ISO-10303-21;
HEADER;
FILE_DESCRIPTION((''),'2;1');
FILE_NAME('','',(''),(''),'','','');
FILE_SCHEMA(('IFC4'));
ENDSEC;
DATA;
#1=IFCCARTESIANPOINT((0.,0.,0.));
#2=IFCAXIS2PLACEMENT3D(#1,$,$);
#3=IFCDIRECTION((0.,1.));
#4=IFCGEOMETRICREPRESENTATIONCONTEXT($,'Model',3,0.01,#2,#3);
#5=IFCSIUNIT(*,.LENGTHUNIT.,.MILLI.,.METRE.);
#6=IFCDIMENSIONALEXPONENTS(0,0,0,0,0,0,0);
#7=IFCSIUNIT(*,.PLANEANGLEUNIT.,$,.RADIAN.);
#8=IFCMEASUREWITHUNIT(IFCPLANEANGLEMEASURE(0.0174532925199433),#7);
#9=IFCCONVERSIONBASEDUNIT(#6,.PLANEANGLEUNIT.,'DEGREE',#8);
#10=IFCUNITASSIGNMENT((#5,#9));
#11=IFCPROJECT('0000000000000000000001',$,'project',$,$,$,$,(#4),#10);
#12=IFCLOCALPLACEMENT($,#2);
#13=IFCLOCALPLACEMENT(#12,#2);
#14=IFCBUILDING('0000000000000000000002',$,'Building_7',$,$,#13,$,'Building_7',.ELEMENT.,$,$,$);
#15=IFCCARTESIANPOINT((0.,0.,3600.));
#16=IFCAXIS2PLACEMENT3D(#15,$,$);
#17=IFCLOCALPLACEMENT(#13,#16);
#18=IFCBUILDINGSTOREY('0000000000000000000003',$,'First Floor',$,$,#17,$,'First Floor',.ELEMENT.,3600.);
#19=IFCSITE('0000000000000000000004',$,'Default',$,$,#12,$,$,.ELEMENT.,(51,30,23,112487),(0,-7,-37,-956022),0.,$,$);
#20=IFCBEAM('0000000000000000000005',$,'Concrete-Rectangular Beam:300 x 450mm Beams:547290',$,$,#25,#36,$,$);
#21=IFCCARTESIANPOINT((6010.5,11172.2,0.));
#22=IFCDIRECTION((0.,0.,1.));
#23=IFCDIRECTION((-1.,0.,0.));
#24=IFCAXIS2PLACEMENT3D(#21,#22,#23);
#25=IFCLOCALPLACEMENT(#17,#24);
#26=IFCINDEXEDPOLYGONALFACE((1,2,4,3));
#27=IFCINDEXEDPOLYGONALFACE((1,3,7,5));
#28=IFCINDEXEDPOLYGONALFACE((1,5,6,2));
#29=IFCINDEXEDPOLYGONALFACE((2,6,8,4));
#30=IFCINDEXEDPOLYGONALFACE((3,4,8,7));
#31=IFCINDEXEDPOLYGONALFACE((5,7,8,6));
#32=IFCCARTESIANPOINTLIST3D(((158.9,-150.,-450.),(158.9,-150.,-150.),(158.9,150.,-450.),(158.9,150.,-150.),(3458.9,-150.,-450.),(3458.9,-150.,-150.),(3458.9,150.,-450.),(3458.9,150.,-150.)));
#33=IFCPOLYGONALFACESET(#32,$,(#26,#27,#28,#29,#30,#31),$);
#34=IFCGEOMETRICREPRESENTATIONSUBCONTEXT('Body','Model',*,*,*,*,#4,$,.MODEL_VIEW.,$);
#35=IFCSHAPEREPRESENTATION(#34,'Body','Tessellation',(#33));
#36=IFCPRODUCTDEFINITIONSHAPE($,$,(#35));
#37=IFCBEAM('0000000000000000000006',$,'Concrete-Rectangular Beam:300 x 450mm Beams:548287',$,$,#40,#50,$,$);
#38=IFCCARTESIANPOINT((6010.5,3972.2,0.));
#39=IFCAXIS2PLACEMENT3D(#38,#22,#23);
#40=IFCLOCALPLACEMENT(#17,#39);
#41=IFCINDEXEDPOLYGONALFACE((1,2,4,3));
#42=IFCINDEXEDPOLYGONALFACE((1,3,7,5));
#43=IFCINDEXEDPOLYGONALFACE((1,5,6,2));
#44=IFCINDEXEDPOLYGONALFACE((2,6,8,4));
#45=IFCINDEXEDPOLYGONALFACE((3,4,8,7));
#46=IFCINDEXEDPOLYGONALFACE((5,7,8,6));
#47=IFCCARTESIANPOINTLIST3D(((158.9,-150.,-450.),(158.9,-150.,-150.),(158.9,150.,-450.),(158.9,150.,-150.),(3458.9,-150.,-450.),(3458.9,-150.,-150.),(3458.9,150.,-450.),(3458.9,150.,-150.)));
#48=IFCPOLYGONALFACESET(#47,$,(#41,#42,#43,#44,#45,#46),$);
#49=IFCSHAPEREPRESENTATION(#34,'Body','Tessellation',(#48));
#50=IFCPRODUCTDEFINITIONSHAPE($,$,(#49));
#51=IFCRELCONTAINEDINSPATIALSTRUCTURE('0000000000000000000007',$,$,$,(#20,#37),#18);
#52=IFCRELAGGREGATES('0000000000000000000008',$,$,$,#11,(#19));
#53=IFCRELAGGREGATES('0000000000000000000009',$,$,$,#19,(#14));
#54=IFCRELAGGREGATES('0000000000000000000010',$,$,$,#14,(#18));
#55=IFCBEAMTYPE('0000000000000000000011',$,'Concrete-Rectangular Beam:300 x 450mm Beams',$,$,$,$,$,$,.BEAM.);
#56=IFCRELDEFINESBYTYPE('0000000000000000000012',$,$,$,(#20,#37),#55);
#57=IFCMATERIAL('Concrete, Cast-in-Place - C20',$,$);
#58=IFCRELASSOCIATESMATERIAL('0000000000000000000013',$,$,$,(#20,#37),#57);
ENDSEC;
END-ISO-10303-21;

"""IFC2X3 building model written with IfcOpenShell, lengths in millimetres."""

from ifc_helpers import new_model, entity, si_unit, converted_unit, direction, frame, frame_2d, origin, place, context, subcontext, project, spatial, rectangle, extrude, material, type_object, element, save


model = new_model("IFC2X3")

# Units and contexts
model_context = context("Model", 3, precision=0.01, world=origin(), true_north=direction((0.0, 1.0)))
body_context = subcontext(model_context, "Body", "Model", "MODEL_VIEW")
ifc_project = project(units=[si_unit("LENGTHUNIT", "METRE", prefix="MILLI"), converted_unit("PLANEANGLEUNIT", "DEGREE", entity("IfcPlaneAngleMeasure", 0.0174532925199433), si_unit("PLANEANGLEUNIT", "RADIAN"), dimensions=[0, 0, 0, 0, 0, 0, 0])], contexts=[model_context])

# Site, building, storey
site_placement = place(None, origin())
site = spatial("IfcSite", under=ifc_project, at=site_placement, Name="Default", CompositionType="ELEMENT", RefLatitude=(51, 30, 23, 112487), RefLongitude=(0, -7, -37, -956022), RefElevation=0.0)
building_placement = place(site_placement, origin())
building = spatial("IfcBuilding", under=site, at=building_placement, Name="Building_7", LongName="Building_7", CompositionType="ELEMENT")
storey_placement = place(building_placement, frame((0.0, 0.0, 3600.0)))
storey = spatial("IfcBuildingStorey", under=building, at=storey_placement, Name="First Floor", LongName="First Floor", CompositionType="ELEMENT", Elevation=3600.0)

# Beams
ifc_material_1 = material(Name="Concrete, Cast-in-Place - C20")
beam_type_1 = type_object("IfcBeamType", Name="Concrete-Rectangular Beam:300 x 450mm Beams", PredefinedType="BEAM")
beam_1_placement = place(storey_placement, frame((6010.5, 11172.2, 0.0), z_axis=(0.0, 0.0, 1.0), x_axis=(-1.0, 0.0, 0.0)))
element("IfcBeam", 1, at=beam_1_placement, inside=storey, type_object=beam_type_1, material=ifc_material_1, Name="Concrete-Rectangular Beam:300 x 450mm Beams:547290", context=body_context, shape_type="SweptSolid", body=[
    extrude(rectangle(XDim=300.0, YDim=300.0, at=frame_2d((0.0, 0.0), x_axis=(1.0, 0.0))), frame((158.9, 0.0, -300.0), z_axis=(1.0, 0.0, 0.0), x_axis=(0.0, 0.0, -1.0)), (0.0, 0.0, 1.0), 3300.0),
])
beam_2_placement = place(storey_placement, frame((6010.5, 3972.2, 0.0), z_axis=(0.0, 0.0, 1.0), x_axis=(-1.0, 0.0, 0.0)))
element("IfcBeam", 2, at=beam_2_placement, inside=storey, type_object=beam_type_1, material=ifc_material_1, Name="Concrete-Rectangular Beam:300 x 450mm Beams:548287", context=body_context, shape_type="SweptSolid", body=[
    extrude(rectangle(XDim=300.0, YDim=300.0, at=frame_2d((0.0, 0.0), x_axis=(1.0, 0.0))), frame((158.9, 0.0, -300.0), z_axis=(1.0, 0.0, 0.0), x_axis=(0.0, 0.0, -1.0)), (0.0, 0.0, 1.0), 3300.0),
])

save(model, "model.ifc")
